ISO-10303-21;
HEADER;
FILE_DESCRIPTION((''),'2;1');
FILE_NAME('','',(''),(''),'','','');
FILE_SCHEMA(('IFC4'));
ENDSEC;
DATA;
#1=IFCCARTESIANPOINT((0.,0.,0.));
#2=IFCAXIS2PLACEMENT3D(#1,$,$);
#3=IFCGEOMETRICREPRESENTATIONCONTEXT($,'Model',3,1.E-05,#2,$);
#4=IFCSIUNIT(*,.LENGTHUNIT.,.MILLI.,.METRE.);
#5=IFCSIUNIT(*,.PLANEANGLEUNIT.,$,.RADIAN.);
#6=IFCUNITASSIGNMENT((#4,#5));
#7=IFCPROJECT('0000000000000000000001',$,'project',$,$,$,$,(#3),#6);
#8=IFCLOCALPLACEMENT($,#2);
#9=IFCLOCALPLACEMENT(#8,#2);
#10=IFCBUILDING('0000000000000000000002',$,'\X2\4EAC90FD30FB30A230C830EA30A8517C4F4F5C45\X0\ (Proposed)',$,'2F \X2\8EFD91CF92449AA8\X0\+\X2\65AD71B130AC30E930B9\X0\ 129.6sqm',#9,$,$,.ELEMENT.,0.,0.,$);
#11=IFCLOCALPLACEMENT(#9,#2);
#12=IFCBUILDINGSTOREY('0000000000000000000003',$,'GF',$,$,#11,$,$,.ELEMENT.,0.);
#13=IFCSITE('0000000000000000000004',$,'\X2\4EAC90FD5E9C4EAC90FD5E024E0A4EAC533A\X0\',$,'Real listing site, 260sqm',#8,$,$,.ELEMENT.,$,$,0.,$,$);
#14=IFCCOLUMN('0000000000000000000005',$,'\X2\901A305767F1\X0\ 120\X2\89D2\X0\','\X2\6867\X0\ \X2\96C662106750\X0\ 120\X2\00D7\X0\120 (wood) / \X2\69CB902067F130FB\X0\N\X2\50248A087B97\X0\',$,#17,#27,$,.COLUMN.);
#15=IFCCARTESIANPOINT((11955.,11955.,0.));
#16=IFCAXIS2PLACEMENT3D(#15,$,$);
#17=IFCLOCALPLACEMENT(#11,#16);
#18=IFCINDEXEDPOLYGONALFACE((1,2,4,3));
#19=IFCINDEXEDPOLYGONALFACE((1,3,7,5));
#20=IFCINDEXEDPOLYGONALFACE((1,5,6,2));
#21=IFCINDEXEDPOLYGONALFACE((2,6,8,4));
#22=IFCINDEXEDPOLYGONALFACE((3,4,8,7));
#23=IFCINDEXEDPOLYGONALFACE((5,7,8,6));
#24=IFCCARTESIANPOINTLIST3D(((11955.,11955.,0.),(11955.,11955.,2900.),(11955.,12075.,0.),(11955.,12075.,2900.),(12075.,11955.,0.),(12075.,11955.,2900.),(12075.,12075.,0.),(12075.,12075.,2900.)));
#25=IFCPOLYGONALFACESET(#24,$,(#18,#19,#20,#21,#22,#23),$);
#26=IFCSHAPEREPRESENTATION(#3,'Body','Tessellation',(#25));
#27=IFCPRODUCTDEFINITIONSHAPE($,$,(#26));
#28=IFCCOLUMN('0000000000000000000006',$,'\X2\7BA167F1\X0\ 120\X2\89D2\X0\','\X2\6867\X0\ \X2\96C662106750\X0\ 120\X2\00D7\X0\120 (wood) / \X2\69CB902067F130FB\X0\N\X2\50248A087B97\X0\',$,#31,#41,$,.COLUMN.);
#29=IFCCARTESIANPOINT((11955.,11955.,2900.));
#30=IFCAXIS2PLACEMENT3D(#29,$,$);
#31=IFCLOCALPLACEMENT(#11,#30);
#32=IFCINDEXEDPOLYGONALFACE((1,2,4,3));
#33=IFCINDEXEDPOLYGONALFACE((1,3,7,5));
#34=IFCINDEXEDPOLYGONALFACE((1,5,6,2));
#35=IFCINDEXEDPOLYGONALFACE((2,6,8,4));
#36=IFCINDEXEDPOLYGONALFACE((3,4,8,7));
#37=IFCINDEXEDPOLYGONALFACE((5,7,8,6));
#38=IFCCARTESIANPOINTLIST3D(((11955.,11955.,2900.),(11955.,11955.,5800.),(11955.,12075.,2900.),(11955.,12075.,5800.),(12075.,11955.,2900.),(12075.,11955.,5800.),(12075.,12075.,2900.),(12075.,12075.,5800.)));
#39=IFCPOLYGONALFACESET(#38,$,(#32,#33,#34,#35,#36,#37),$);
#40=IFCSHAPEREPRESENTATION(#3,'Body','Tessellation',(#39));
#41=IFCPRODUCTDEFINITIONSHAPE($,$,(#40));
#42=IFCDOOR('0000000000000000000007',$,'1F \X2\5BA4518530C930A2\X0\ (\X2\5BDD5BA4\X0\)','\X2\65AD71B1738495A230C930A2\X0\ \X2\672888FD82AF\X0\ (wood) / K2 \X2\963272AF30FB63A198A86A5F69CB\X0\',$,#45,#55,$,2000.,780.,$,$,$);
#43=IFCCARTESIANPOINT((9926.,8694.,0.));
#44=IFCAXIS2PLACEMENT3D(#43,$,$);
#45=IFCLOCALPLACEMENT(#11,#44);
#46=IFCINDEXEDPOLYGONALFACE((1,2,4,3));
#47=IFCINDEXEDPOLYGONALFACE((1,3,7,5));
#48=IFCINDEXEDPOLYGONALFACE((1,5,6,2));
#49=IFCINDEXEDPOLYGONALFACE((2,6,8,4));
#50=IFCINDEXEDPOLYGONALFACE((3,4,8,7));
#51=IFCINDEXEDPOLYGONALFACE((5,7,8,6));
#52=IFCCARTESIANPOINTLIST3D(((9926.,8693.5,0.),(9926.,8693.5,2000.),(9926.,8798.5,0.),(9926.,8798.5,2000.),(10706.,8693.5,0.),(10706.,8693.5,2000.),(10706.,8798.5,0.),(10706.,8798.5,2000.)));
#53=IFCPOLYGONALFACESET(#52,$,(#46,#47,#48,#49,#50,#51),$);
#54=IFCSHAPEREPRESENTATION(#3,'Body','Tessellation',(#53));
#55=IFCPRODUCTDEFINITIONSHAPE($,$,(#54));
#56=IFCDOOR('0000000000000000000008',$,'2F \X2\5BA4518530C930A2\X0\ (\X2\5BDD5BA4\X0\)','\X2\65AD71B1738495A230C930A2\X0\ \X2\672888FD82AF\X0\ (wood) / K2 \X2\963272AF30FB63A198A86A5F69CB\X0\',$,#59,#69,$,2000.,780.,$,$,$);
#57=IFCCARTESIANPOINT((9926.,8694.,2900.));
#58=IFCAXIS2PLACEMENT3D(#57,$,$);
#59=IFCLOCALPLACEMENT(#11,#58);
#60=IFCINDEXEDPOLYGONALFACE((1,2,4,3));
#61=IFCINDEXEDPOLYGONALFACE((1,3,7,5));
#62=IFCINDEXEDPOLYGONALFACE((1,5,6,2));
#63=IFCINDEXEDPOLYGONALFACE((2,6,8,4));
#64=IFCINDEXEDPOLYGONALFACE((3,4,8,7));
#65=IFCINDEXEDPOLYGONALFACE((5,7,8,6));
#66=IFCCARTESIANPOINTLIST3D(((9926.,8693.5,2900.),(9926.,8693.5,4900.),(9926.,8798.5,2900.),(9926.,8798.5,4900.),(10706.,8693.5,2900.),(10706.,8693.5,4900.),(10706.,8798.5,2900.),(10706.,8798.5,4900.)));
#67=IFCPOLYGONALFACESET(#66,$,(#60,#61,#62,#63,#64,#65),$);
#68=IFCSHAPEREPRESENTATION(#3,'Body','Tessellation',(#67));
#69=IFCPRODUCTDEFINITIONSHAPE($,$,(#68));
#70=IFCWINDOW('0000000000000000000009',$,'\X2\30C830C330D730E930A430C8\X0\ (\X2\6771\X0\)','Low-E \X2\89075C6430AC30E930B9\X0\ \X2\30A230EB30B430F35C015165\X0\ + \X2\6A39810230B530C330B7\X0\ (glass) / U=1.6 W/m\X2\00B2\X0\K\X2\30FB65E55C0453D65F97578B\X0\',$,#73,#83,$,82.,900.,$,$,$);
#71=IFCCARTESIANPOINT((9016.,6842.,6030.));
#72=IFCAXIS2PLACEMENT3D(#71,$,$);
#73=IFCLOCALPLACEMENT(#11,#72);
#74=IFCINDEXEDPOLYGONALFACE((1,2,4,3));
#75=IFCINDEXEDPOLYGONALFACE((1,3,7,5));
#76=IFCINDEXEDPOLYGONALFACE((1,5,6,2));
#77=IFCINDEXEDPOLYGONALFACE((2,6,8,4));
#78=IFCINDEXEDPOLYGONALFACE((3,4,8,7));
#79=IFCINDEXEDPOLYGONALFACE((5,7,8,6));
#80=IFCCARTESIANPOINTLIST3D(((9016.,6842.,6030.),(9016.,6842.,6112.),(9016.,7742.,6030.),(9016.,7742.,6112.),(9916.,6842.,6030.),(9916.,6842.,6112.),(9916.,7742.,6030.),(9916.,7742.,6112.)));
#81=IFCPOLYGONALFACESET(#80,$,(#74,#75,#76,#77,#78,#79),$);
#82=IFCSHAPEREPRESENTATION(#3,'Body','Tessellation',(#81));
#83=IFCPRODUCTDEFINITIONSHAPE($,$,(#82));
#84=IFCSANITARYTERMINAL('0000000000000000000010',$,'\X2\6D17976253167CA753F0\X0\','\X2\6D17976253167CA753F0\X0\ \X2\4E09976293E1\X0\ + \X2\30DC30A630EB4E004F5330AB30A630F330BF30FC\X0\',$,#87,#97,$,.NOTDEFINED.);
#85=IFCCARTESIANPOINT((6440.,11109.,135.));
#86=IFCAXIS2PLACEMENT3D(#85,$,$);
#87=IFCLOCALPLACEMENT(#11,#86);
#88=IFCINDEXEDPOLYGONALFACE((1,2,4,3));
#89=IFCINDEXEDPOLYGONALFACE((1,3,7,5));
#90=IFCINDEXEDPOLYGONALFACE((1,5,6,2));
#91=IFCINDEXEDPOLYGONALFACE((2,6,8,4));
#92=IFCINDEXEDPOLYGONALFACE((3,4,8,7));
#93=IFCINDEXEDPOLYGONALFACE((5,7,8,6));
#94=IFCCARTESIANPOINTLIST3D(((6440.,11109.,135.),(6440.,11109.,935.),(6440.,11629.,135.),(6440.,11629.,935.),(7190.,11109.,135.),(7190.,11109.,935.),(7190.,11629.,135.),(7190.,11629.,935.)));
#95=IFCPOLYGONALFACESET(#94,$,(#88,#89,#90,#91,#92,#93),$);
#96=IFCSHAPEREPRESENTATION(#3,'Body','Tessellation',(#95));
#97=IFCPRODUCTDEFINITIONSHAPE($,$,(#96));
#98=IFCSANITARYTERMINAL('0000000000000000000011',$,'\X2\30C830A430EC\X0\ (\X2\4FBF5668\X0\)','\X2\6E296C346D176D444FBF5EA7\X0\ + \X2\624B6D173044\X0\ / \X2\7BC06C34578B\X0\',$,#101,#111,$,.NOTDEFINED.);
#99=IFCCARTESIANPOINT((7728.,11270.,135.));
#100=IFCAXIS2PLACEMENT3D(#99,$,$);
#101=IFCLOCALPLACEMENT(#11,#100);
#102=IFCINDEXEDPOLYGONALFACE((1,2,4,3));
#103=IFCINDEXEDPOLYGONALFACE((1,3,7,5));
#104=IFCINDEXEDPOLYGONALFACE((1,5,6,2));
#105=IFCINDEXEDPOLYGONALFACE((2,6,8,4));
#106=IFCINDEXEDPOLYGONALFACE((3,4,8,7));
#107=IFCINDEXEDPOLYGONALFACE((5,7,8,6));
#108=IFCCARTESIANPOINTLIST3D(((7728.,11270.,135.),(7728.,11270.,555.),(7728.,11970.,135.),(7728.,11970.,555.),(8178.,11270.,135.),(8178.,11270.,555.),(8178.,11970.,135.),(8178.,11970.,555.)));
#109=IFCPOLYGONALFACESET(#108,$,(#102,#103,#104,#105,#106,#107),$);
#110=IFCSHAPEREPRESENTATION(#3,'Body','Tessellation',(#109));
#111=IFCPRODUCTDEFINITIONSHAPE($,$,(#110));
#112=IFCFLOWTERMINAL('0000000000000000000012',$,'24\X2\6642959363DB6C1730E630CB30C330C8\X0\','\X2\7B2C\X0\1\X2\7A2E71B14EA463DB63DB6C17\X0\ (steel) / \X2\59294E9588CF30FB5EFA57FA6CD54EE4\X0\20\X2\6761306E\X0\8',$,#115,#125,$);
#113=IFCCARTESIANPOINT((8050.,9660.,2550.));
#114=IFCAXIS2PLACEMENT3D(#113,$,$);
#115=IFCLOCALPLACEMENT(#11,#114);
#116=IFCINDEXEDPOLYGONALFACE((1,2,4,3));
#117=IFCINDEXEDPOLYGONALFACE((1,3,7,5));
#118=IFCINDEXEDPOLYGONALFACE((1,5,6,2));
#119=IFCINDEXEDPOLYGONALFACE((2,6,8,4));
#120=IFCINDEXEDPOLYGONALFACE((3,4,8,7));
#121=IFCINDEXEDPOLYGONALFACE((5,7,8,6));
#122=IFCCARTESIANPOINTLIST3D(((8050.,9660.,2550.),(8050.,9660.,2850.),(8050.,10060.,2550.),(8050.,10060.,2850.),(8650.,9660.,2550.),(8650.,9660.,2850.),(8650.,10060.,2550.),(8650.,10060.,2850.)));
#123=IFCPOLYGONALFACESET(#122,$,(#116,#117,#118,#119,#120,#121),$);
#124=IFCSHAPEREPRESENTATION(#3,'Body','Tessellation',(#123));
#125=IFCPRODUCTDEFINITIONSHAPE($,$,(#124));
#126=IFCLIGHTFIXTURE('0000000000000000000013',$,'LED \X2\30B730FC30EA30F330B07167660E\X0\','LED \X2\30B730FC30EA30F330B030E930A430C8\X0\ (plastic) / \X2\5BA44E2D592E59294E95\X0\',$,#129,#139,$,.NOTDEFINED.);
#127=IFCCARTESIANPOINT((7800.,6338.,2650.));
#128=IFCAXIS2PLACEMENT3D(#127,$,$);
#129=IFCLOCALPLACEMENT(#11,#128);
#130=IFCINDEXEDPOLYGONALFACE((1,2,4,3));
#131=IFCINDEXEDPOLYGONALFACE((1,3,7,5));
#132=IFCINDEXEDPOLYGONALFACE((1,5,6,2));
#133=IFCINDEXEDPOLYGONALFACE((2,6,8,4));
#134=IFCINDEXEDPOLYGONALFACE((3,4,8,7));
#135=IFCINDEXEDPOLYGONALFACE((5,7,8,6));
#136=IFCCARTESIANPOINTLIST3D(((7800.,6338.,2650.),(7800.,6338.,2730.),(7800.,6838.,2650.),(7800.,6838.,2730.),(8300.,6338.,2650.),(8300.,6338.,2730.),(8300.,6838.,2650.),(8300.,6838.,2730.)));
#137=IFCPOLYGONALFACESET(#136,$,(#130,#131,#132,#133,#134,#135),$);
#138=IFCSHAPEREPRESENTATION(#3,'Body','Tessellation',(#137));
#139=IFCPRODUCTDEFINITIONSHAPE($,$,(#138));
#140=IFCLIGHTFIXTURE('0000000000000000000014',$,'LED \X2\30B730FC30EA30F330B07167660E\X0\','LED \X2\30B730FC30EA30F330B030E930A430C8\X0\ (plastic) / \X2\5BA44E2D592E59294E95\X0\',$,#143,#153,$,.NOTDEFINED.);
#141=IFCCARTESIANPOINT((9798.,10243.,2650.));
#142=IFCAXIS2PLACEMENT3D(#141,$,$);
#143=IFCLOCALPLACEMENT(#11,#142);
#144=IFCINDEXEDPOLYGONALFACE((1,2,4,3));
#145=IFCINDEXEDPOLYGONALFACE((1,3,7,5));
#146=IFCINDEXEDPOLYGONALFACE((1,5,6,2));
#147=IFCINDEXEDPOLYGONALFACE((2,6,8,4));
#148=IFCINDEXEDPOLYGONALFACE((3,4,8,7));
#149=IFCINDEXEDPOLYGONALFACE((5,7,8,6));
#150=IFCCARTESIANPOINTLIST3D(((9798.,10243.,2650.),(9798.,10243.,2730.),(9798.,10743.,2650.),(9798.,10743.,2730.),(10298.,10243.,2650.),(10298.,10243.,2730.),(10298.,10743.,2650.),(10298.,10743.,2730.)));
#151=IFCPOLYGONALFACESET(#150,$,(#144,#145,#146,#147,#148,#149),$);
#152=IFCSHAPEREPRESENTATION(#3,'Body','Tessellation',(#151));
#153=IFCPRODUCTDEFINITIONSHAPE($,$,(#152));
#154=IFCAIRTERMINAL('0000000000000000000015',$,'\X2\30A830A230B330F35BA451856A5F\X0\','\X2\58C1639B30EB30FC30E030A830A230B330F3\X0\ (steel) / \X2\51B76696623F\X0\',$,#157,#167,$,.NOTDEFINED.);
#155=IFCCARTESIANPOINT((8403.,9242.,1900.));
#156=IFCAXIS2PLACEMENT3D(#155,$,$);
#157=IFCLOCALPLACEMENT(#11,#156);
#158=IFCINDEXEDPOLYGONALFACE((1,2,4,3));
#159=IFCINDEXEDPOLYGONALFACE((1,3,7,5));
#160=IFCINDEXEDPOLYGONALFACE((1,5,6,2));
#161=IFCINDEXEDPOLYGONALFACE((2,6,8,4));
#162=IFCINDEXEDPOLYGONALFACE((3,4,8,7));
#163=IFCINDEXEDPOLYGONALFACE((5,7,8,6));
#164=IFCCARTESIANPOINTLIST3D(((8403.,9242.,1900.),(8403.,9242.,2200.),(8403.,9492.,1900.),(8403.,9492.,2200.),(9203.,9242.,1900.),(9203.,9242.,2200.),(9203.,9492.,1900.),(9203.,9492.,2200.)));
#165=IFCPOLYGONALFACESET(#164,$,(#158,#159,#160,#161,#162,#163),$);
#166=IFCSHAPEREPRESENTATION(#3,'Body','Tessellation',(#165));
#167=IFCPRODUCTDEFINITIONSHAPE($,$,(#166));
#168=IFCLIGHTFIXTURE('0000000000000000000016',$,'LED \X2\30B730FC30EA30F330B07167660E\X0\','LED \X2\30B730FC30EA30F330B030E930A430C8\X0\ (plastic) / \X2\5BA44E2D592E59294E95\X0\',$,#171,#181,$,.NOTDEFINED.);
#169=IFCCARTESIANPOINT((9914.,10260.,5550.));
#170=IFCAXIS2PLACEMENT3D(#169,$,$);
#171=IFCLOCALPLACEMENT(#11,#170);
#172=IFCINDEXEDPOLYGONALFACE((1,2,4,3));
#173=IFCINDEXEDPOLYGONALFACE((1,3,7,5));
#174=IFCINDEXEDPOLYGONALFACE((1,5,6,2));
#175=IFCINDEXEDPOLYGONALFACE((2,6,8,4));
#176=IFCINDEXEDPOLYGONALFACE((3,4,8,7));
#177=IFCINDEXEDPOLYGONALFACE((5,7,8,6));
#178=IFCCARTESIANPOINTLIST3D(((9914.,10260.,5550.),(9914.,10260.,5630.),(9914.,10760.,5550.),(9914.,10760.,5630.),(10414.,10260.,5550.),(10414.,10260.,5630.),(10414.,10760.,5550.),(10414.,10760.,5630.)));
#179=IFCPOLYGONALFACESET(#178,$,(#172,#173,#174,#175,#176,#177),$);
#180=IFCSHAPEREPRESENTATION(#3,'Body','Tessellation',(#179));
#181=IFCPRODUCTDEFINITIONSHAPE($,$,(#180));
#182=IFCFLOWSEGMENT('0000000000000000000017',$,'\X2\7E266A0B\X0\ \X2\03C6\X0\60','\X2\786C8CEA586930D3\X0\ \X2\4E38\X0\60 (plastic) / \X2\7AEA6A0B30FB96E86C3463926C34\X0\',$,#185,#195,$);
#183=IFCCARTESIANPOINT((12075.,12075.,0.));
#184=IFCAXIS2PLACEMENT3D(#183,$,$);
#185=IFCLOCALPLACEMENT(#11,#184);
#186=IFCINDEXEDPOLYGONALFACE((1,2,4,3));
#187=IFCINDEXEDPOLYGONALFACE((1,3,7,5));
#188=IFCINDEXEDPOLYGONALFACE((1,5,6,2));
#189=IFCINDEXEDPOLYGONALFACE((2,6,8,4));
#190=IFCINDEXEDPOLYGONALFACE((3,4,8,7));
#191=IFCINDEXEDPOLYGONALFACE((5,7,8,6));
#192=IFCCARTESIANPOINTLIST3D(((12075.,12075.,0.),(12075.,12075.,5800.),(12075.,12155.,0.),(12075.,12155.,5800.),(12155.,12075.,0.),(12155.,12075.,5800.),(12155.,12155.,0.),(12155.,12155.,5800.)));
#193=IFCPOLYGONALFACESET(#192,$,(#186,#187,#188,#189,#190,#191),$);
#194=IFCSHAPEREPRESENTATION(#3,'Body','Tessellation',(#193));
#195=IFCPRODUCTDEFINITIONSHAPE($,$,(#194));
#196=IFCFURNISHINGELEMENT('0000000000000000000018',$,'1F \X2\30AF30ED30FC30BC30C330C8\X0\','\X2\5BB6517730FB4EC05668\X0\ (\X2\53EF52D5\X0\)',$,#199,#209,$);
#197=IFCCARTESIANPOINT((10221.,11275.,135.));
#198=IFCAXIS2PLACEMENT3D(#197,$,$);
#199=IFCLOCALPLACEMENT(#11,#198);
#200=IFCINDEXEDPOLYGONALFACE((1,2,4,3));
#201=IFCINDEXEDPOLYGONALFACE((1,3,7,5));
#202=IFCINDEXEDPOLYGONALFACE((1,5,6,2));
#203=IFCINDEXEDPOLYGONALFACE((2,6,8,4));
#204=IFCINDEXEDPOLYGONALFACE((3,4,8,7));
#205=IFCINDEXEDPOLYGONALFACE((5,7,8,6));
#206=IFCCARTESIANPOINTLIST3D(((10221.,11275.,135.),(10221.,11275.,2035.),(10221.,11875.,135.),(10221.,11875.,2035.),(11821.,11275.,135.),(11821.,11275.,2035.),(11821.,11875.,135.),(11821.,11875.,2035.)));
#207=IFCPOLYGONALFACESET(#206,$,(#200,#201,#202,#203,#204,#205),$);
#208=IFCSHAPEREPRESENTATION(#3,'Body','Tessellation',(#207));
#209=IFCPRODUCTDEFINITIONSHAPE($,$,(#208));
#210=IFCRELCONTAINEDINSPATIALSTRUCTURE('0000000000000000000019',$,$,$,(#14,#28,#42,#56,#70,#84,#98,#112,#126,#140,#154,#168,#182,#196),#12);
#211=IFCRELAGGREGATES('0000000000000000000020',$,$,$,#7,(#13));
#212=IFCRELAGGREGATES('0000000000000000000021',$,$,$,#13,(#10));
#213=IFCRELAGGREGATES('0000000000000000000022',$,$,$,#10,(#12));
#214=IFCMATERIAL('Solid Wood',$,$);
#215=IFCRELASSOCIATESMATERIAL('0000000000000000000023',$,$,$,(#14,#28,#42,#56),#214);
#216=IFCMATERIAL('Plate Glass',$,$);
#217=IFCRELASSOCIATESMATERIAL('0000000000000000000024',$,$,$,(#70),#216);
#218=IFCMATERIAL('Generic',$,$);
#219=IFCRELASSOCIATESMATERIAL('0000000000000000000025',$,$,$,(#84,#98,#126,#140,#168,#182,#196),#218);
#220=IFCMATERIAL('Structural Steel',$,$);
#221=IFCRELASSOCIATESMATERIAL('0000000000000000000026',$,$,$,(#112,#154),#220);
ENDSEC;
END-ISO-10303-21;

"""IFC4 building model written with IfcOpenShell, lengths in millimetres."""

from ifc_helpers import new_model, si_unit, frame, frame_2d, origin, place, context, project, spatial, rectangle, extrude, material, element, save


model = new_model("IFC4")

# Units and contexts
model_context = context("Model", 3, precision=1e-05, world=origin())
ifc_project = project(units=[si_unit("LENGTHUNIT", "METRE", prefix="MILLI"), si_unit("PLANEANGLEUNIT", "RADIAN")], contexts=[model_context])

# Site, building, storey
site_placement = place(None, origin())
site = spatial("IfcSite", under=ifc_project, at=site_placement, Name="京都府京都市上京区", ObjectType="Real listing site, 260sqm", CompositionType="ELEMENT", RefElevation=0.0)
building_placement = place(site_placement, origin())
building = spatial("IfcBuilding", under=site, at=building_placement, Name="京都・アトリエ兼住居 (Proposed)", ObjectType="2F 軽量鉄骨+断熱ガラス 129.6sqm", CompositionType="ELEMENT", ElevationOfRefHeight=0.0, ElevationOfTerrain=0.0)
storey_placement = place(building_placement, origin())
storey = spatial("IfcBuildingStorey", under=building, at=storey_placement, Name="GF", CompositionType="ELEMENT", Elevation=0.0)

# Columns
ifc_material_1 = material(Name="Solid Wood")
column_1_placement = place(storey_placement, frame((11955.0, 11955.0, 0.0)))
element("IfcColumn", 1, at=column_1_placement, inside=storey, material=ifc_material_1, Name="通し柱 120角", Description="桧 集成材 120×120 (wood) / 構造柱・N値計算", PredefinedType="COLUMN", context=model_context, shape_type="SweptSolid", body=[
    extrude(rectangle(XDim=120.0, YDim=120.0, at=frame_2d((60.0, 60.0))), frame((11955.0, 11955.0, 0.0)), (0.0, 0.0, 1.0), 2900.0),
])
column_2_placement = place(storey_placement, frame((11955.0, 11955.0, 2900.0)))
element("IfcColumn", 2, at=column_2_placement, inside=storey, material=ifc_material_1, Name="管柱 120角", Description="桧 集成材 120×120 (wood) / 構造柱・N値計算", PredefinedType="COLUMN", context=model_context, shape_type="SweptSolid", body=[
    extrude(rectangle(XDim=120.0, YDim=120.0, at=frame_2d((60.0, 60.0))), frame((11955.0, 11955.0, 2900.0)), (0.0, 0.0, 1.0), 2900.0),
])

# Door
door_1_placement = place(storey_placement, frame((9926.0, 8694.0, 0.0)))
element("IfcDoor", 3, at=door_1_placement, inside=storey, material=ifc_material_1, Name="1F 室内ドア (寝室)", Description="断熱玄関ドア 木製芯 (wood) / K2 防犯・採風機構", OverallHeight=2000.0, OverallWidth=780.0, context=model_context, shape_type="SweptSolid", body=[
    extrude(rectangle(XDim=780.0, YDim=105.0, at=frame_2d((390.0, 52.0))), frame((9926.0, 8694.0, 0.0)), (0.0, 0.0, 1.0), 2000.0),
])

# Door
door_2_placement = place(storey_placement, frame((9926.0, 8694.0, 2900.0)))
element("IfcDoor", 4, at=door_2_placement, inside=storey, material=ifc_material_1, Name="2F 室内ドア (寝室)", Description="断熱玄関ドア 木製芯 (wood) / K2 防犯・採風機構", OverallHeight=2000.0, OverallWidth=780.0, context=model_context, shape_type="SweptSolid", body=[
    extrude(rectangle(XDim=780.0, YDim=105.0, at=frame_2d((390.0, 52.0))), frame((9926.0, 8694.0, 2900.0)), (0.0, 0.0, 1.0), 2000.0),
])

# Window
ifc_material_2 = material(Name="Plate Glass")
window_placement = place(storey_placement, frame((9016.0, 6842.0, 6030.0)))
element("IfcWindow", 5, at=window_placement, inside=storey, material=ifc_material_2, Name="トップライト (東)", Description="Low-E 複層ガラス アルゴン封入 + 樹脂サッシ (glass) / U=1.6 W/m²K・日射取得型", OverallHeight=82.0, OverallWidth=900.0, context=model_context, shape_type="SweptSolid", body=[
    extrude(rectangle(XDim=900.0, YDim=900.0, at=frame_2d((450.0, 450.0))), frame((9016.0, 6842.0, 6030.0)), (0.0, 0.0, 1.0), 82.0),
])

# Sanitary terminals
ifc_material_3 = material(Name="Generic")
sanitary_terminal_1_placement = place(storey_placement, frame((6440.0, 11109.0, 135.0)))
element("IfcSanitaryTerminal", 6, at=sanitary_terminal_1_placement, inside=storey, material=ifc_material_3, Name="洗面化粧台", Description="洗面化粧台 三面鏡 + ボウル一体カウンター", PredefinedType="NOTDEFINED", context=model_context, shape_type="SweptSolid", body=[
    extrude(rectangle(XDim=750.0, YDim=520.0, at=frame_2d((375.0, 260.0))), frame((6440.0, 11109.0, 135.0)), (0.0, 0.0, 1.0), 800.0),
])
sanitary_terminal_2_placement = place(storey_placement, frame((7728.0, 11270.0, 135.0)))
element("IfcSanitaryTerminal", 7, at=sanitary_terminal_2_placement, inside=storey, material=ifc_material_3, Name="トイレ (便器)", Description="温水洗浄便座 + 手洗い / 節水型", PredefinedType="NOTDEFINED", context=model_context, shape_type="SweptSolid", body=[
    extrude(rectangle(XDim=450.0, YDim=700.0, at=frame_2d((225.0, 350.0))), frame((7728.0, 11270.0, 135.0)), (0.0, 0.0, 1.0), 420.0),
])

# Flow terminal
ifc_material_4 = material(Name="Structural Steel")
flow_terminal_placement = place(storey_placement, frame((8050.0, 9660.0, 2550.0)))
element("IfcFlowTerminal", 8, at=flow_terminal_placement, inside=storey, material=ifc_material_4, Name="24時間換気ユニット", Description="第1種熱交換換気 (steel) / 天井裏・建基法令20条の8", context=model_context, shape_type="SweptSolid", body=[
    extrude(rectangle(XDim=600.0, YDim=400.0, at=frame_2d((300.0, 200.0))), frame((8050.0, 9660.0, 2550.0)), (0.0, 0.0, 1.0), 300.0),
])

# Light fixtures
light_fixture_1_placement = place(storey_placement, frame((7800.0, 6338.0, 2650.0)))
element("IfcLightFixture", 9, at=light_fixture_1_placement, inside=storey, material=ifc_material_3, Name="LED シーリング照明", Description="LED シーリングライト (plastic) / 室中央天井", PredefinedType="NOTDEFINED", context=model_context, shape_type="SweptSolid", body=[
    extrude(rectangle(XDim=500.0, YDim=500.0, at=frame_2d((250.0, 250.0))), frame((7800.0, 6338.0, 2650.0)), (0.0, 0.0, 1.0), 80.0),
])
light_fixture_2_placement = place(storey_placement, frame((9798.0, 10243.0, 2650.0)))
element("IfcLightFixture", 10, at=light_fixture_2_placement, inside=storey, material=ifc_material_3, Name="LED シーリング照明", Description="LED シーリングライト (plastic) / 室中央天井", PredefinedType="NOTDEFINED", context=model_context, shape_type="SweptSolid", body=[
    extrude(rectangle(XDim=500.0, YDim=500.0, at=frame_2d((250.0, 250.0))), frame((9798.0, 10243.0, 2650.0)), (0.0, 0.0, 1.0), 80.0),
])

# Air terminal
air_terminal_placement = place(storey_placement, frame((8403.0, 9242.0, 1900.0)))
element("IfcAirTerminal", 11, at=air_terminal_placement, inside=storey, material=ifc_material_4, Name="エアコン室内機", Description="壁掛ルームエアコン (steel) / 冷暖房", PredefinedType="NOTDEFINED", context=model_context, shape_type="SweptSolid", body=[
    extrude(rectangle(XDim=800.0, YDim=250.0, at=frame_2d((400.0, 125.0))), frame((8403.0, 9242.0, 1900.0)), (0.0, 0.0, 1.0), 300.0),
])

# Light fixture
light_fixture_3_placement = place(storey_placement, frame((9914.0, 10260.0, 5550.0)))
element("IfcLightFixture", 12, at=light_fixture_3_placement, inside=storey, material=ifc_material_3, Name="LED シーリング照明", Description="LED シーリングライト (plastic) / 室中央天井", PredefinedType="NOTDEFINED", context=model_context, shape_type="SweptSolid", body=[
    extrude(rectangle(XDim=500.0, YDim=500.0, at=frame_2d((250.0, 250.0))), frame((9914.0, 10260.0, 5550.0)), (0.0, 0.0, 1.0), 80.0),
])

# Flow segment
flow_segment_placement = place(storey_placement, frame((12075.0, 12075.0, 0.0)))
element("IfcFlowSegment", 13, at=flow_segment_placement, inside=storey, material=ifc_material_3, Name="縦樋 φ60", Description="硬質塩ビ 丸60 (plastic) / 竪樋・雨水排水", context=model_context, shape_type="SweptSolid", body=[
    extrude(rectangle(XDim=80.0, YDim=80.0, at=frame_2d((40.0, 40.0))), frame((12075.0, 12075.0, 0.0)), (0.0, 0.0, 1.0), 5800.0),
])

# Furnishing element
furnishing_1_placement = place(storey_placement, frame((10221.0, 11275.0, 135.0)))
element("IfcFurnishingElement", 14, at=furnishing_1_placement, inside=storey, material=ifc_material_3, Name="1F クローゼット", Description="家具・什器 (可動)", context=model_context, shape_type="SweptSolid", body=[
    extrude(rectangle(XDim=1600.0, YDim=600.0, at=frame_2d((800.0, 300.0))), frame((10221.0, 11275.0, 135.0)), (0.0, 0.0, 1.0), 1900.0),
])

save(model, "model.ifc")
